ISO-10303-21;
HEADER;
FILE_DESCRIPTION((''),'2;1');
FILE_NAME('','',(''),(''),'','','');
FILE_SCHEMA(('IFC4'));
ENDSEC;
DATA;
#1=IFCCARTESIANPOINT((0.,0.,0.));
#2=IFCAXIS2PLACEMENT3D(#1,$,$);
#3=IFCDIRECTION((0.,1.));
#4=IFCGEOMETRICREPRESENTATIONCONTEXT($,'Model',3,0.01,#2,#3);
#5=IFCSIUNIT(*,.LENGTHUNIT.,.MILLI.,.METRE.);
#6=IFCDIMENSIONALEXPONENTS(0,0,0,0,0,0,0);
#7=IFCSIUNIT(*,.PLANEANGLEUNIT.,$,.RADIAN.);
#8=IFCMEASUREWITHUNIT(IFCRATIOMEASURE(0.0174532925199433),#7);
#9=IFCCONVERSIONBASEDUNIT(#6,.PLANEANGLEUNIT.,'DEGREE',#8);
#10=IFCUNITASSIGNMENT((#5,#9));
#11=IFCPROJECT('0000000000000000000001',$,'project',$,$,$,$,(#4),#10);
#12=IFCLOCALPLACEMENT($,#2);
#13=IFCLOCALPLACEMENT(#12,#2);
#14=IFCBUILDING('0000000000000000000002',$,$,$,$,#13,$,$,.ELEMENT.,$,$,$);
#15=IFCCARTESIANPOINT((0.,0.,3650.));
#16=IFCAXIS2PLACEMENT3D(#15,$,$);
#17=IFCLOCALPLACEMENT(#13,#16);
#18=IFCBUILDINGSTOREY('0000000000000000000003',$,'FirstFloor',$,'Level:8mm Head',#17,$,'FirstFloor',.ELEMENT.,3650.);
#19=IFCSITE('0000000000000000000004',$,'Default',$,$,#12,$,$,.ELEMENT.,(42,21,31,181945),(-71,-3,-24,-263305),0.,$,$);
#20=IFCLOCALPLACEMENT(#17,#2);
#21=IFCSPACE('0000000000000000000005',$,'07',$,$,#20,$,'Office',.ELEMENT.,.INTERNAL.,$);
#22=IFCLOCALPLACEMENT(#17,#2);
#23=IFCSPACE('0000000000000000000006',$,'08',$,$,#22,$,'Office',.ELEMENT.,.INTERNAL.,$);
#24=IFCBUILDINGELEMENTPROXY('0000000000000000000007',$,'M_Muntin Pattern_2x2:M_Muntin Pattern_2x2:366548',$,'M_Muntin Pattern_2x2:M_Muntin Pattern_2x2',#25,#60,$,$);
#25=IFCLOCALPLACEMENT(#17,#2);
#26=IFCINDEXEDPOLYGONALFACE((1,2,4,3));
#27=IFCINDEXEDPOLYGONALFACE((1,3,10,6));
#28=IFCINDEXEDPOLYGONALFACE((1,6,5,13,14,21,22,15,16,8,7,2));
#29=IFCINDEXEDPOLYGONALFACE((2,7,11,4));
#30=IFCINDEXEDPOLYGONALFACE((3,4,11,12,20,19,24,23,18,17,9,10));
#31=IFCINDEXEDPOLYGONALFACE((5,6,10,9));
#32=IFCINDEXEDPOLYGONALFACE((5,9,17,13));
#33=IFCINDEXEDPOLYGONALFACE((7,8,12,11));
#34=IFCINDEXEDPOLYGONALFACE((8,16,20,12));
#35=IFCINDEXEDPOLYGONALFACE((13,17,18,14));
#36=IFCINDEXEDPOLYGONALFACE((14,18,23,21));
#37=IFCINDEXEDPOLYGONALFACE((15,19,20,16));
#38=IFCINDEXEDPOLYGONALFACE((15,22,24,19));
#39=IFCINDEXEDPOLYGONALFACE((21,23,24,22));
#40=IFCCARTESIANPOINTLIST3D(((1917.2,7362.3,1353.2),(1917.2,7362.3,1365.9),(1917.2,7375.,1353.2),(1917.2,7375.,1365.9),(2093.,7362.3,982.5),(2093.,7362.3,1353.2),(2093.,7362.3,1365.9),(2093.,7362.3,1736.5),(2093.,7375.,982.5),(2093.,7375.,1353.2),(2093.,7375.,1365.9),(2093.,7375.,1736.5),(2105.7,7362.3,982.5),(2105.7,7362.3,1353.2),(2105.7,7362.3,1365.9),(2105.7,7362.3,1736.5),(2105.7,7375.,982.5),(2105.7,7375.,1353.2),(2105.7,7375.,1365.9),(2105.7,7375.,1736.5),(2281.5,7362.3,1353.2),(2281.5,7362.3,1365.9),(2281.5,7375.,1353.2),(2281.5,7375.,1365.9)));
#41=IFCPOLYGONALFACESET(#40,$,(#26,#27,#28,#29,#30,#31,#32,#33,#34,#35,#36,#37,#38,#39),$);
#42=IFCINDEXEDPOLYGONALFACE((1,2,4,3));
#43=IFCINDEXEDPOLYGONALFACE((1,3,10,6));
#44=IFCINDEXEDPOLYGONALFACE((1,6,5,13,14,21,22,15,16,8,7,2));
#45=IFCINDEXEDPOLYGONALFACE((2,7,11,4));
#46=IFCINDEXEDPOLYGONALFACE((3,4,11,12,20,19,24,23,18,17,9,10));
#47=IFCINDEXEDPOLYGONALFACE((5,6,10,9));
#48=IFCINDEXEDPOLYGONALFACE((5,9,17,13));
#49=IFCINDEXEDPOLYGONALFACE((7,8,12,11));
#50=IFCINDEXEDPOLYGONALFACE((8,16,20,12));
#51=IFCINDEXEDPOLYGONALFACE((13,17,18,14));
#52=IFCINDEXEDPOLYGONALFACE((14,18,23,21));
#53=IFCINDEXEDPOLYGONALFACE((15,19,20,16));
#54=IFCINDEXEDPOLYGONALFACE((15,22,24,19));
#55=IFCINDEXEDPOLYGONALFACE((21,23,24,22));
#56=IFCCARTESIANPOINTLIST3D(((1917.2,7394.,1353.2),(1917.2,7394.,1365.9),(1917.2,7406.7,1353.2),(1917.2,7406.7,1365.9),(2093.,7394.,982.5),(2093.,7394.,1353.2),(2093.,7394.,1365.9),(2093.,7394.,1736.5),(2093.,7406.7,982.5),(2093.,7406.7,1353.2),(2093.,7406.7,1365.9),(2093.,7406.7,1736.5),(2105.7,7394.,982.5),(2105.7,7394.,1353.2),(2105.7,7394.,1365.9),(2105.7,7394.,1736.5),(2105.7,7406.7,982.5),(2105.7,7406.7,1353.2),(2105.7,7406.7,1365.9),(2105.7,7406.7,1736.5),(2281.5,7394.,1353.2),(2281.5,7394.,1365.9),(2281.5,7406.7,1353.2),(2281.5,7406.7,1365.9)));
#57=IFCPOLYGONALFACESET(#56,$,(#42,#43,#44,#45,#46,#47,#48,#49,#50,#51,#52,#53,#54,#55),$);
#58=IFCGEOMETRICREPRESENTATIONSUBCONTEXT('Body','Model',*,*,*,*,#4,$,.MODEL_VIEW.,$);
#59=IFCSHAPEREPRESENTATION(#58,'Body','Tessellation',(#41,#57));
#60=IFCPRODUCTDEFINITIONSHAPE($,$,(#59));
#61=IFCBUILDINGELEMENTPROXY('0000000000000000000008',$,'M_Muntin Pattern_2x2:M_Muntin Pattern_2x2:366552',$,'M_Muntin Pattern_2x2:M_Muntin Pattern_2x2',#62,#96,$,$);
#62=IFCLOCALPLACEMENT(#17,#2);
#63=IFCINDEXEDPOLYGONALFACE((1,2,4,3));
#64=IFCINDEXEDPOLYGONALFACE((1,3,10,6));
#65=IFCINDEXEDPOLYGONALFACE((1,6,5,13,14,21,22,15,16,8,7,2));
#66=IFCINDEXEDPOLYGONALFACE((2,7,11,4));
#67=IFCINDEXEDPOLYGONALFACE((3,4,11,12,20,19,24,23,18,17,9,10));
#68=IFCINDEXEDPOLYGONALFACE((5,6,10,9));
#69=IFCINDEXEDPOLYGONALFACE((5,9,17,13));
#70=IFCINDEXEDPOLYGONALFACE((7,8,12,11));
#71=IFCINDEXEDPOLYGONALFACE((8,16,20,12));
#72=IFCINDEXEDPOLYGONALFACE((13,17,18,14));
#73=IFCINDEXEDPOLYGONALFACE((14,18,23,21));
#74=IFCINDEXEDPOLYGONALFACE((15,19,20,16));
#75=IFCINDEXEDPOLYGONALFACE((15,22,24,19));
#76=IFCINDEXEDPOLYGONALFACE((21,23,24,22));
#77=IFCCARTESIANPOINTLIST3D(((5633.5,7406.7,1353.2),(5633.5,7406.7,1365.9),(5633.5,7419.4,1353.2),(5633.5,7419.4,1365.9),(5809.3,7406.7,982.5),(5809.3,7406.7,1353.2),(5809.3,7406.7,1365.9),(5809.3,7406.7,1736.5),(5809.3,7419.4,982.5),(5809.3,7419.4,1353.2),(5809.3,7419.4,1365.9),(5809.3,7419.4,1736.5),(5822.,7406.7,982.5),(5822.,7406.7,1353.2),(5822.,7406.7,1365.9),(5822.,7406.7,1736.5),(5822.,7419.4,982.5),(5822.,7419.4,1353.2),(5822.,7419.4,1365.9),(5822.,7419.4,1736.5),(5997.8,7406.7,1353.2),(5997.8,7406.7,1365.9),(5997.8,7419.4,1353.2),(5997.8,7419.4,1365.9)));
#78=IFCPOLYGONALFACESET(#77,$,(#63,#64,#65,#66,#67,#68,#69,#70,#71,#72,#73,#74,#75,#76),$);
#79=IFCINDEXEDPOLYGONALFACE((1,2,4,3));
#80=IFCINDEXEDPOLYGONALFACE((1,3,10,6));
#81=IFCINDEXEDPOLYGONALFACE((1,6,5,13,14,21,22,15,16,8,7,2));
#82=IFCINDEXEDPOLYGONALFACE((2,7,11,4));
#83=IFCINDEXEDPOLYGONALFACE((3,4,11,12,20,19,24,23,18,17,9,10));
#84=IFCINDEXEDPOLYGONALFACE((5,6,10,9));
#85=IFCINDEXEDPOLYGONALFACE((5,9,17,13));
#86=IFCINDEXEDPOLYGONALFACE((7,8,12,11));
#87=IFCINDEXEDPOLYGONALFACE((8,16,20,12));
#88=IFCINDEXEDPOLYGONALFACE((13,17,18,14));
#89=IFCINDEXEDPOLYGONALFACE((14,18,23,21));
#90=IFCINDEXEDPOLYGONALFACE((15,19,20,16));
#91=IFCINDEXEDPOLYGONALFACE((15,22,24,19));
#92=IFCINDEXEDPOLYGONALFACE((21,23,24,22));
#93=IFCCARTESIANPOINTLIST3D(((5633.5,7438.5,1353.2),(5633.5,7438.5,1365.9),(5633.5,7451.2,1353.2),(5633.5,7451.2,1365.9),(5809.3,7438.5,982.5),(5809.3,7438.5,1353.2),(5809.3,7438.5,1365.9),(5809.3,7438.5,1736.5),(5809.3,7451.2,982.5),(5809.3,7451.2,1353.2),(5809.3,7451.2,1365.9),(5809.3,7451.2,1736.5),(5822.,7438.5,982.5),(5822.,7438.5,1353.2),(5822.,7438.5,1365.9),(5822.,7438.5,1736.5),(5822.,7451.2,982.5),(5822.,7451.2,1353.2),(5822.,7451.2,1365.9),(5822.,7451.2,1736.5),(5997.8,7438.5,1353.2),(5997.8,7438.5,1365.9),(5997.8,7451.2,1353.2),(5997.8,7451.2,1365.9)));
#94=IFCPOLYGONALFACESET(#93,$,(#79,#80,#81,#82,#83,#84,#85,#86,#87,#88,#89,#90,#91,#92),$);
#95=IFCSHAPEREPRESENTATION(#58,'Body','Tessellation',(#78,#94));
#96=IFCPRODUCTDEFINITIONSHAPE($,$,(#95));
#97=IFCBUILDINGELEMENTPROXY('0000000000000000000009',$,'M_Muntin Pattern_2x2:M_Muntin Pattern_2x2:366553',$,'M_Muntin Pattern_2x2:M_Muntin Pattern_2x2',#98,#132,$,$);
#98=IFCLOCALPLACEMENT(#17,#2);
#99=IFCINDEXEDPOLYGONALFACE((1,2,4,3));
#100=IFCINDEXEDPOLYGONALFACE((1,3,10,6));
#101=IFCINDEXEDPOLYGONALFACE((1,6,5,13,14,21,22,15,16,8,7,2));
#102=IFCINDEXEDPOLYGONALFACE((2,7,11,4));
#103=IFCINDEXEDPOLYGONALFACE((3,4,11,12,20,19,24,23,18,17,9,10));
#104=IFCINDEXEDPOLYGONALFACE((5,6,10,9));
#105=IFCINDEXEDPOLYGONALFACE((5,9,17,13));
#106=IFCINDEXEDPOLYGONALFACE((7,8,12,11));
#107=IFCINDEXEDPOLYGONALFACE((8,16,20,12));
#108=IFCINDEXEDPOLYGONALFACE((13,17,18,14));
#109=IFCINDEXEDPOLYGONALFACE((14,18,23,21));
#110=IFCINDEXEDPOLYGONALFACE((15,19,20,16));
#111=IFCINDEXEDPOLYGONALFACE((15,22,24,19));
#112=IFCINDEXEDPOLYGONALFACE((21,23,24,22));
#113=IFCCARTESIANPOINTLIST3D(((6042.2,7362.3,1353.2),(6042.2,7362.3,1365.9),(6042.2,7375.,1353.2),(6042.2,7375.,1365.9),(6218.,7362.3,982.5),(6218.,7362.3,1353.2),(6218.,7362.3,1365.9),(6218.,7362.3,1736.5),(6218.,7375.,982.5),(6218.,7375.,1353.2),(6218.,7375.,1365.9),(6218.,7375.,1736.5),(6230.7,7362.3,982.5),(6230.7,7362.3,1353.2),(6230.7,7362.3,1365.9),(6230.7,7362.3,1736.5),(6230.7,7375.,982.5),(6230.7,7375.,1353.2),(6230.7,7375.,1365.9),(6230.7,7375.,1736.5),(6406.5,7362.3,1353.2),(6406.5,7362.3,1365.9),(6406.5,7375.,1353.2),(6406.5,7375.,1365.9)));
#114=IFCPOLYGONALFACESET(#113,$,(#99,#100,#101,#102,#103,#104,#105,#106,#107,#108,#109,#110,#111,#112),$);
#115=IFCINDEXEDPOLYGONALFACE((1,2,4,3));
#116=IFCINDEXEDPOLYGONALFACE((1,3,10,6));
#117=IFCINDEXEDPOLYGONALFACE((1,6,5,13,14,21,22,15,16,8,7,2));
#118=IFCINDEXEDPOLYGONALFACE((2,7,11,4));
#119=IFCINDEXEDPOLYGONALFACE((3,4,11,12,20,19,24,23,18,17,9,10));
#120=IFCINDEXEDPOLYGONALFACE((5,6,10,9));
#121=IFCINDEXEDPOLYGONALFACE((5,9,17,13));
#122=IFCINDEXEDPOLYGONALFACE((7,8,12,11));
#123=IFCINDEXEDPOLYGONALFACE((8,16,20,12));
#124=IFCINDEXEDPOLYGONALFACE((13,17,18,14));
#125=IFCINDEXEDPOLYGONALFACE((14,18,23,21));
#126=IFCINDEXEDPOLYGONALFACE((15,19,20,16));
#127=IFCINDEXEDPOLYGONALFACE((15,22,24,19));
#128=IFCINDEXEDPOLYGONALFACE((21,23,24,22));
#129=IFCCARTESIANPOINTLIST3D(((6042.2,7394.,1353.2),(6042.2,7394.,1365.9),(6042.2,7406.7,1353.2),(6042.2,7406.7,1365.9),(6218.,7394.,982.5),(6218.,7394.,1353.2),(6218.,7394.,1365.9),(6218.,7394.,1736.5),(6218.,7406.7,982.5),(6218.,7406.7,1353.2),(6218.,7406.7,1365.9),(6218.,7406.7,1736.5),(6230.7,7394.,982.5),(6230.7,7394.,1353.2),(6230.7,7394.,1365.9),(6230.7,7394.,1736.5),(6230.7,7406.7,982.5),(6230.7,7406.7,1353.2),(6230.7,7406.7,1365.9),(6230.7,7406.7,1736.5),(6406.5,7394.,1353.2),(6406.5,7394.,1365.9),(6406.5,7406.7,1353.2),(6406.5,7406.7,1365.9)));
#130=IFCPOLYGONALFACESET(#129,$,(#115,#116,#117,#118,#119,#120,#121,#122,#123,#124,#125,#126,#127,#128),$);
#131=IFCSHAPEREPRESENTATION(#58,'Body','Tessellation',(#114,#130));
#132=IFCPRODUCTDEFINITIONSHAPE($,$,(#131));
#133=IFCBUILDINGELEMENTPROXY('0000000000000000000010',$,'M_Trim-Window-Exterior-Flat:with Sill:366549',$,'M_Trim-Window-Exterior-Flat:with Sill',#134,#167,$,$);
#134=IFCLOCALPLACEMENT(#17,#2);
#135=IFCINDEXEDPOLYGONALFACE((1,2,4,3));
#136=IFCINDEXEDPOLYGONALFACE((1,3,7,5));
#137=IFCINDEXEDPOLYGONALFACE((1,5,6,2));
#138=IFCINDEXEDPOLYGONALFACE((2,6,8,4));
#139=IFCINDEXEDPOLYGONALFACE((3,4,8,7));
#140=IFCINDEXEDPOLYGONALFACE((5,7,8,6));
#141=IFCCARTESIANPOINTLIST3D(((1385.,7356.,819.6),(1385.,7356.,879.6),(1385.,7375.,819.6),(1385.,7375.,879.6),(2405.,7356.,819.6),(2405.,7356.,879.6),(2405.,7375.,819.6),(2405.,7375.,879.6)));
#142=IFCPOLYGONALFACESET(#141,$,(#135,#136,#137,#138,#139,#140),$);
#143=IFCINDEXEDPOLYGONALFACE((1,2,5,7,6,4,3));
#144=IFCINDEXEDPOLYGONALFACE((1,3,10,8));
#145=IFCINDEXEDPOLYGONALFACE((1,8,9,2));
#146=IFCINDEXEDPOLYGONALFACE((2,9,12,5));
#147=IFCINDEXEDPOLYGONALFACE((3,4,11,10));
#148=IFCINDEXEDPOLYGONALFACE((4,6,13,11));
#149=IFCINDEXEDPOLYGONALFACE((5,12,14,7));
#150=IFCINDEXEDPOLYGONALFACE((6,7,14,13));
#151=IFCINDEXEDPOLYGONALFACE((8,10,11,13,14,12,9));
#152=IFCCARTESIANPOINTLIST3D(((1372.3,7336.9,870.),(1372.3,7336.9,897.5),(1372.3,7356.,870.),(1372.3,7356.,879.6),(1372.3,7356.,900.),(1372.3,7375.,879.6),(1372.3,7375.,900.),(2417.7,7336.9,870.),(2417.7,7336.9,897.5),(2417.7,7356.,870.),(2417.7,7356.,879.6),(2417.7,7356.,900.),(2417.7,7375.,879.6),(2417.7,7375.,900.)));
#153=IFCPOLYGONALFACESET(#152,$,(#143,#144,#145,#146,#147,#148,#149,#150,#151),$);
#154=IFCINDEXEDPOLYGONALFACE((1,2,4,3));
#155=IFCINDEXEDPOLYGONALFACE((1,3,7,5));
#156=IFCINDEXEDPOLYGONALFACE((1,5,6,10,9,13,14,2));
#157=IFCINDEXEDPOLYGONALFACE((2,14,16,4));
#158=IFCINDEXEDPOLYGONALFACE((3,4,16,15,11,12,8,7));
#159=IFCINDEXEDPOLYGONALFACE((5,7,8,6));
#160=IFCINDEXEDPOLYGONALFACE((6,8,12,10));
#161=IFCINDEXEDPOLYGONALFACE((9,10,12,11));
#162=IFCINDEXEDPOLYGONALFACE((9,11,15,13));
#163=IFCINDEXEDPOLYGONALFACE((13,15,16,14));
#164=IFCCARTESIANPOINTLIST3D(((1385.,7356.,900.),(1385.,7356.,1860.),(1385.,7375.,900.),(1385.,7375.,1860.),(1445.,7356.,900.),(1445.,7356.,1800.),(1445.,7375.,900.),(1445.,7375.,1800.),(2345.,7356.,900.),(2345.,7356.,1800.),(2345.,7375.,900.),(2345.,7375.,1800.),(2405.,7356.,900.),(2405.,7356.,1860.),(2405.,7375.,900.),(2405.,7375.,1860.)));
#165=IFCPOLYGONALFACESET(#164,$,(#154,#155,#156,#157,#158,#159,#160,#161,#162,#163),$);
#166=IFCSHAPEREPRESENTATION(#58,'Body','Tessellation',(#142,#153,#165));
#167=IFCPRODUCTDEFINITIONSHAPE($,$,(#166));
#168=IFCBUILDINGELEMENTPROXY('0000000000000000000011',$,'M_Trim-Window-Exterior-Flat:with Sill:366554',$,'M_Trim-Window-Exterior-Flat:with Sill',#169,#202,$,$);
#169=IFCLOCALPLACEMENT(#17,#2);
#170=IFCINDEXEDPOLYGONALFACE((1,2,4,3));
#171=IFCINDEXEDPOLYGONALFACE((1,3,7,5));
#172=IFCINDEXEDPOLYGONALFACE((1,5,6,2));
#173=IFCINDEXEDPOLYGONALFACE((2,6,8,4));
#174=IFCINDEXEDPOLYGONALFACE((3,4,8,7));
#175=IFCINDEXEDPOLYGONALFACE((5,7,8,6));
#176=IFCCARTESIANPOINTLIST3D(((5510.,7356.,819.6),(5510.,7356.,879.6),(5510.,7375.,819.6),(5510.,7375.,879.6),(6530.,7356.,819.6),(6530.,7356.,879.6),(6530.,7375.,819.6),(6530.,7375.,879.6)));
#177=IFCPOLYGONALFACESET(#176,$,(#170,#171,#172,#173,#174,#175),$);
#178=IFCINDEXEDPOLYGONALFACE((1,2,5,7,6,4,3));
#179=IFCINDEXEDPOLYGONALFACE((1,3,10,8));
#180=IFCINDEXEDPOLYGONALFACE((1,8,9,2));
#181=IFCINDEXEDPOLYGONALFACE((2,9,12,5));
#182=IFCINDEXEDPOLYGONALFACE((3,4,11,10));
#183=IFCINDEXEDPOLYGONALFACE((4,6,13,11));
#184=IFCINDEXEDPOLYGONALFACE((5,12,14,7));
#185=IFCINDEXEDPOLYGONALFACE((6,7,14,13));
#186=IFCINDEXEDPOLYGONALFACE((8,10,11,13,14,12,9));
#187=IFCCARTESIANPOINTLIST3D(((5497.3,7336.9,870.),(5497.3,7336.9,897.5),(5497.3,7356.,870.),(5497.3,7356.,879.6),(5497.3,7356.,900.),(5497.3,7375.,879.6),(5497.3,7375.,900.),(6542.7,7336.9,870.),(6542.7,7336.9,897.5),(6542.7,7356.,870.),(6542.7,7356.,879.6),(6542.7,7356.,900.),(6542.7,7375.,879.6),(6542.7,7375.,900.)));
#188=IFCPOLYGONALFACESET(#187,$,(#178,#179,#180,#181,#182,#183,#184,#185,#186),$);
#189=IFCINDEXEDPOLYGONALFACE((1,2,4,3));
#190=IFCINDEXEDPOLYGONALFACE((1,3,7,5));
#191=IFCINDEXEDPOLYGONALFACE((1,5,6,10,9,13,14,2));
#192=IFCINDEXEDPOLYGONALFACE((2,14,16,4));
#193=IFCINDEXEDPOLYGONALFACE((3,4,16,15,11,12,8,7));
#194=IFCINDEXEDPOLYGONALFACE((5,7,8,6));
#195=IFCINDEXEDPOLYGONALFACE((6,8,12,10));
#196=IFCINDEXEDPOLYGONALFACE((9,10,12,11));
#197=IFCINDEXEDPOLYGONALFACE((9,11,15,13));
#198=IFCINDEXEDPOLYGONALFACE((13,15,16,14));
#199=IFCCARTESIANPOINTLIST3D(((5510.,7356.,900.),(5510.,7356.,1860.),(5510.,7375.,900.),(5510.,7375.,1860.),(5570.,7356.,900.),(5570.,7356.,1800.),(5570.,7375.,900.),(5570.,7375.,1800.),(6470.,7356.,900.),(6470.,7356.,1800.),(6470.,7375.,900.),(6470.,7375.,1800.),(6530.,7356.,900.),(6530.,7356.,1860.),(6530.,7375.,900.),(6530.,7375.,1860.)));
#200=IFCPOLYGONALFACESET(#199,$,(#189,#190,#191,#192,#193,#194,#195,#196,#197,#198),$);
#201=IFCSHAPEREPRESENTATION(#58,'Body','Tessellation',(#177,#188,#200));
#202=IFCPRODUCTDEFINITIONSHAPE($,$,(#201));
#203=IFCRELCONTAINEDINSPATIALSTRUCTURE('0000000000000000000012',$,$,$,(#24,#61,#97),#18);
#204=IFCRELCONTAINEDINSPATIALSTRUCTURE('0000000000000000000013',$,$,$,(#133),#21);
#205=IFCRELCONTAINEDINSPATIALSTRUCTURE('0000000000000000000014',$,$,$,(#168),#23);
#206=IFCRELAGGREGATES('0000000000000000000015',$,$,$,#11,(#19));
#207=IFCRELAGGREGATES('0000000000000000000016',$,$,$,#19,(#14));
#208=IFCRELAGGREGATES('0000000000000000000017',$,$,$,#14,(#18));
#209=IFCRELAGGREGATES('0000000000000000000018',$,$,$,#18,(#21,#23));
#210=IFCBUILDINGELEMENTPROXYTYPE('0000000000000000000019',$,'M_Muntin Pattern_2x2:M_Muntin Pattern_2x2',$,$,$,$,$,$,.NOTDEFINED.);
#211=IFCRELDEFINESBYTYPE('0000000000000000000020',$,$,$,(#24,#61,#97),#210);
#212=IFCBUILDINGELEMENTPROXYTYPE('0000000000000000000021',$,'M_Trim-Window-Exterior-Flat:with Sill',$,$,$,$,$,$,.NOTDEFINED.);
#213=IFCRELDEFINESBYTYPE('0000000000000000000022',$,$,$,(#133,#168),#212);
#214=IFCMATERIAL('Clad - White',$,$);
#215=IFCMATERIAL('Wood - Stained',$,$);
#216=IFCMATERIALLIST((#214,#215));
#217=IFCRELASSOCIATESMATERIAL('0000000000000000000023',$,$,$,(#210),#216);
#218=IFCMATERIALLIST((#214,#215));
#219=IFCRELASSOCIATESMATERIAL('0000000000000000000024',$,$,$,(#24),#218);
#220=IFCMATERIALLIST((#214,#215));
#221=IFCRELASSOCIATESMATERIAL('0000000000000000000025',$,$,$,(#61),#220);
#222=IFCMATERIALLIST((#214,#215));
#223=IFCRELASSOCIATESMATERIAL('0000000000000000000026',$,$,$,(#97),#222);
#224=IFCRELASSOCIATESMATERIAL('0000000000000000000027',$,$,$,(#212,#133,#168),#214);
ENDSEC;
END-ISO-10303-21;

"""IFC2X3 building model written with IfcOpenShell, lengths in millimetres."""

from ifc_helpers import new_model, entity, si_unit, converted_unit, direction, frame, frame_2d, origin, place, context, subcontext, project, spatial, polyline, rectangle, outline, extrude, source, transform, mapped, material, material_list, type_object, type_shapes, element, save


model = new_model("IFC2X3")

# Units and contexts
model_context = context("Model", 3, precision=0.01, world=origin(), true_north=direction((0.0, 1.0)))
body_context = subcontext(model_context, "Body", "Model", "MODEL_VIEW")
ifc_project = project(units=[si_unit("LENGTHUNIT", "METRE", prefix="MILLI"), converted_unit("PLANEANGLEUNIT", "DEGREE", entity("IfcRatioMeasure", 0.0174532925199433), si_unit("PLANEANGLEUNIT", "RADIAN"), dimensions=[0, 0, 0, 0, 0, 0, 0])], contexts=[model_context])

# Site, building, storey
site_placement = place(None, origin())
site = spatial("IfcSite", under=ifc_project, at=site_placement, Name="Default", CompositionType="ELEMENT", RefLatitude=(42, 21, 31, 181945), RefLongitude=(-71, -3, -24, -263305), RefElevation=0.0)
building_placement = place(site_placement, origin())
building = spatial("IfcBuilding", under=site, at=building_placement, CompositionType="ELEMENT")
storey_placement = place(building_placement, frame((0.0, 0.0, 3650.0)))
storey = spatial("IfcBuildingStorey", under=building, at=storey_placement, Name="FirstFloor", ObjectType="Level:8mm Head", LongName="FirstFloor", CompositionType="ELEMENT", Elevation=3650.0)

# Shared definitions
ifc_material_1 = material(Name="Clad - White")
ifc_material_2 = material(Name="Wood - Stained")

# Shared definitions
space_1_placement = place(storey_placement, origin())
space_1 = spatial("IfcSpace", under=storey, at=space_1_placement, Name="07", LongName="Office", CompositionType="ELEMENT", InteriorOrExteriorSpace="INTERNAL")

# Building element proxies
ifc_material_list_1 = material_list([ifc_material_1, ifc_material_2])
building_element_proxy_type_1 = type_object("IfcBuildingElementProxyType", Name="M_Muntin Pattern_2x2:M_Muntin Pattern_2x2", PredefinedType="NOTDEFINED", material=ifc_material_list_1)
shared_shape_1 = source(origin(), body_context, "Body", "SweptSolid", [
    extrude(outline(polyline([(6.4, -6.4), (377.0, -6.4), (377.0, 6.3), (6.4, 6.3), (6.4, 182.1), (-6.3, 182.1), (-6.3, 6.3), (-377.0, 6.3), (-377.0, -6.4), (-6.3, -6.4), (-6.3, -182.1), (6.4, -182.1), (6.4, -6.4)])), frame((0.0, 9.5, 377.0), z_axis=(0.0, 1.0, 0.0), x_axis=(0.0, 0.0, 1.0)), (0.0, 0.0, 1.0), 12.7),
    extrude(outline(polyline([(6.4, -6.4), (377.0, -6.4), (377.0, 6.3), (6.4, 6.3), (6.4, 182.1), (-6.3, 182.1), (-6.3, 6.3), (-377.0, 6.3), (-377.0, -6.4), (-6.3, -6.4), (-6.3, -182.1), (6.4, -182.1), (6.4, -6.4)])), frame((0.0, -22.2, 377.0), z_axis=(0.0, 1.0, 0.0), x_axis=(0.0, 0.0, 1.0)), (0.0, 0.0, 1.0), 12.7),
])
type_shapes(building_element_proxy_type_1, [shared_shape_1])
ifc_material_list_2 = material_list([ifc_material_1, ifc_material_2])
proxy_1_placement = place(storey_placement, frame((2099.4, 7384.5, 982.5), z_axis=(0.0, 0.0, 1.0), x_axis=(-1.0, 0.0, 0.0)))
element("IfcBuildingElementProxy", 1, at=proxy_1_placement, inside=storey, type_object=building_element_proxy_type_1, material=ifc_material_list_2, Name="M_Muntin Pattern_2x2:M_Muntin Pattern_2x2:366548", ObjectType="M_Muntin Pattern_2x2:M_Muntin Pattern_2x2", context=body_context, shape_type="MappedRepresentation", body=[
    mapped(shared_shape_1, transform((0.0, 0.0, 0.0), scale=1.0)),
])
ifc_material_list_3 = material_list([ifc_material_1, ifc_material_2])
proxy_2_placement = place(storey_placement, frame((5815.6, 7429.0, 982.5), z_axis=(0.0, 0.0, 1.0), x_axis=(-1.0, 0.0, 0.0)))
element("IfcBuildingElementProxy", 2, at=proxy_2_placement, inside=storey, type_object=building_element_proxy_type_1, material=ifc_material_list_3, Name="M_Muntin Pattern_2x2:M_Muntin Pattern_2x2:366552", ObjectType="M_Muntin Pattern_2x2:M_Muntin Pattern_2x2", context=body_context, shape_type="MappedRepresentation", body=[
    mapped(shared_shape_1, transform((0.0, 0.0, 0.0), scale=1.0)),
])
ifc_material_list_4 = material_list([ifc_material_1, ifc_material_2])
proxy_3_placement = place(storey_placement, frame((6224.4, 7384.5, 982.5), z_axis=(0.0, 0.0, 1.0), x_axis=(-1.0, 0.0, 0.0)))
element("IfcBuildingElementProxy", 3, at=proxy_3_placement, inside=storey, type_object=building_element_proxy_type_1, material=ifc_material_list_4, Name="M_Muntin Pattern_2x2:M_Muntin Pattern_2x2:366553", ObjectType="M_Muntin Pattern_2x2:M_Muntin Pattern_2x2", context=body_context, shape_type="MappedRepresentation", body=[
    mapped(shared_shape_1, transform((0.0, 0.0, 0.0), scale=1.0)),
])
building_element_proxy_type_2 = type_object("IfcBuildingElementProxyType", Name="M_Trim-Window-Exterior-Flat:with Sill", PredefinedType="NOTDEFINED", material=ifc_material_1)
shared_shape_2 = source(origin(), body_context, "Body", "SweptSolid", [
    extrude(rectangle(XDim=1020.0, YDim=60.0, at=frame_2d((0.0, 0.0), x_axis=(1.0, 0.0))), frame((0.0, -950.4, 0.0), z_axis=(0.0, 0.0, 1.0), x_axis=(-1.0, 0.0, 0.0)), (0.0, 0.0, 1.0), 19.1),
    extrude(outline(polyline([(-19.0, -15.2), (0.0, -15.2), (0.0, -5.7), (19.0, -5.7), (19.0, 14.8), (0.0, 14.8), (-19.0, 12.3), (-19.0, -15.2)])), frame((-522.7, -914.8, 19.0), z_axis=(1.0, 0.0, 0.0), x_axis=(0.0, 0.0, -1.0)), (0.0, 0.0, 1.0), 1045.4),
    extrude(outline(polyline([(-495.0, -510.0), (465.0, -510.0), (465.0, -450.0), (-435.0, -450.0), (-435.0, 450.0), (465.0, 450.0), (465.0, 510.0), (-495.0, 510.0), (-495.0, -510.0)])), frame((0.0, -435.0, 0.0), z_axis=(0.0, 0.0, 1.0), x_axis=(0.0, -1.0, 0.0)), (0.0, 0.0, 1.0), 19.1),
])
type_shapes(building_element_proxy_type_2, [shared_shape_2])
proxy_4_placement = place(space_1_placement, frame((1895.0, 7375.0, 1800.0), z_axis=(0.0, -1.0, 0.0), x_axis=(1.0, 0.0, 0.0)))
element("IfcBuildingElementProxy", 4, at=proxy_4_placement, inside=space_1, type_object=building_element_proxy_type_2, material=ifc_material_1, Name="M_Trim-Window-Exterior-Flat:with Sill:366549", ObjectType="M_Trim-Window-Exterior-Flat:with Sill", context=body_context, shape_type="MappedRepresentation", body=[
    mapped(shared_shape_2, transform((0.0, 0.0, 0.0), scale=1.0)),
])

# Shared definitions
space_2_placement = place(storey_placement, origin())
space_2 = spatial("IfcSpace", under=storey, at=space_2_placement, Name="08", LongName="Office", CompositionType="ELEMENT", InteriorOrExteriorSpace="INTERNAL")

# Building element proxy
proxy_5_placement = place(space_2_placement, frame((6020.0, 7375.0, 1800.0), z_axis=(0.0, -1.0, 0.0), x_axis=(1.0, 0.0, 0.0)))
element("IfcBuildingElementProxy", 5, at=proxy_5_placement, inside=space_2, type_object=building_element_proxy_type_2, material=ifc_material_1, Name="M_Trim-Window-Exterior-Flat:with Sill:366554", ObjectType="M_Trim-Window-Exterior-Flat:with Sill", context=body_context, shape_type="MappedRepresentation", body=[
    mapped(shared_shape_2, transform((0.0, 0.0, 0.0), scale=1.0)),
])

save(model, "model.ifc")
